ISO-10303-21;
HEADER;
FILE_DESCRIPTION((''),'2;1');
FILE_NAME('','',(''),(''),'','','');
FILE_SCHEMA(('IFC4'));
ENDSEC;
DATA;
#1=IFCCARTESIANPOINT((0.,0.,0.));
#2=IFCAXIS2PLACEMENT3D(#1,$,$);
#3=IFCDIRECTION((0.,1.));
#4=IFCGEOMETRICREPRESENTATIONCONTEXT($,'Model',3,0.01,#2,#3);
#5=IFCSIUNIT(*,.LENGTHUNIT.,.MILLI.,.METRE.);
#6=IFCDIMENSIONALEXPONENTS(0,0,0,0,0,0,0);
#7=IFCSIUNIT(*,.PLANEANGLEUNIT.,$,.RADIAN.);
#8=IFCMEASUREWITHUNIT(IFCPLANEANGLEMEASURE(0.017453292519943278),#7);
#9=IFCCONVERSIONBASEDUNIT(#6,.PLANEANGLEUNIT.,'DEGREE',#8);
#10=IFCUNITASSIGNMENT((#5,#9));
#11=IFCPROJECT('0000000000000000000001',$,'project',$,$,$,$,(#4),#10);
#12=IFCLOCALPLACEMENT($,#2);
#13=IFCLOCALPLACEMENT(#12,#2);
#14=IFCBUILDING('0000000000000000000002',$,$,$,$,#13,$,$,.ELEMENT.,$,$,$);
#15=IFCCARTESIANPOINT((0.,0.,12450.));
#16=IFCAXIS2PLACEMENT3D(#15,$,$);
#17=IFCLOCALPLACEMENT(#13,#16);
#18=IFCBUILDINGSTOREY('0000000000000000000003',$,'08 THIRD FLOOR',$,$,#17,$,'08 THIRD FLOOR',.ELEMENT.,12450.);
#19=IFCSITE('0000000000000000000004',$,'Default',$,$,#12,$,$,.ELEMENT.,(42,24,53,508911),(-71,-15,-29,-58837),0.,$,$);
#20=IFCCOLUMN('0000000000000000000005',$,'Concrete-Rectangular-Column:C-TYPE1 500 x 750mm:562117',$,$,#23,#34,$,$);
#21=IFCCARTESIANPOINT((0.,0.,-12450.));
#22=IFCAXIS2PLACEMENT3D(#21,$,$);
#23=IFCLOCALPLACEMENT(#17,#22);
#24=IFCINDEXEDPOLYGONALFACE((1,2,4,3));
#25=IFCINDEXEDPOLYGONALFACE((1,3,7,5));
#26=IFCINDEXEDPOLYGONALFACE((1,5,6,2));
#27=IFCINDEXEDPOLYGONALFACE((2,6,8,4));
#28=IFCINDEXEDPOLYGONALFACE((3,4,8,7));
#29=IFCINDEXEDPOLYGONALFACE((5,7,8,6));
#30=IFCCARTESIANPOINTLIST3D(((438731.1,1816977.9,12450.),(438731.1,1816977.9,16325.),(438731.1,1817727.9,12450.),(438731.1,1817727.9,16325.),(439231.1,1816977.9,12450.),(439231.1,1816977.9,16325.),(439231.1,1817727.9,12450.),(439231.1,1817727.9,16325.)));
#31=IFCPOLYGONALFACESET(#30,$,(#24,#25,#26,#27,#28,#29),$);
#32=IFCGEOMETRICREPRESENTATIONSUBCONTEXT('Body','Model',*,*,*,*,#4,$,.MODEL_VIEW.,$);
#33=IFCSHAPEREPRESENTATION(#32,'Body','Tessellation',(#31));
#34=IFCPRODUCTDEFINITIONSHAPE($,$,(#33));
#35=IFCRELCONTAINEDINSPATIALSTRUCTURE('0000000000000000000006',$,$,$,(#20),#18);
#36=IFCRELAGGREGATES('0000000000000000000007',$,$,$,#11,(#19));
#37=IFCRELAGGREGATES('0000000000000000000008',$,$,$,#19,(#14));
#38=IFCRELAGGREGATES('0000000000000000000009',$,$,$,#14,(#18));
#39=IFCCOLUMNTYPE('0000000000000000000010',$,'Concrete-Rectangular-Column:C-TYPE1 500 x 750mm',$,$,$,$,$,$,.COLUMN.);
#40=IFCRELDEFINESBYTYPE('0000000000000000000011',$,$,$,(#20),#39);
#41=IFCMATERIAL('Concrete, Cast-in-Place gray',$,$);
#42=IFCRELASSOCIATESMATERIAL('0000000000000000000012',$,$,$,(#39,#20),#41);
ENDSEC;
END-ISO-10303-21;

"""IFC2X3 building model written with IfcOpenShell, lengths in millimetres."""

from ifc_helpers import new_model, entity, si_unit, converted_unit, direction, frame, frame_2d, origin, place, context, subcontext, project, spatial, rectangle, extrude, source, transform, mapped, material, type_object, type_shapes, element, save


model = new_model("IFC2X3")

# Units and contexts
model_context = context("Model", 3, precision=0.01, world=origin(), true_north=direction((0.0, 1.0)))
body_context = subcontext(model_context, "Body", "Model", "MODEL_VIEW")
ifc_project = project(units=[si_unit("LENGTHUNIT", "METRE", prefix="MILLI"), converted_unit("PLANEANGLEUNIT", "DEGREE", entity("IfcPlaneAngleMeasure", 0.017453292519943278), si_unit("PLANEANGLEUNIT", "RADIAN"), dimensions=[0, 0, 0, 0, 0, 0, 0])], contexts=[model_context])

# Site, building, storey
site_placement = place(None, origin())
site = spatial("IfcSite", under=ifc_project, at=site_placement, Name="Default", CompositionType="ELEMENT", RefLatitude=(42, 24, 53, 508911), RefLongitude=(-71, -15, -29, -58837), RefElevation=0.0)
building_placement = place(site_placement, origin())
building = spatial("IfcBuilding", under=site, at=building_placement, CompositionType="ELEMENT")
storey_placement = place(building_placement, frame((0.0, 0.0, 12450.0)))
storey = spatial("IfcBuildingStorey", under=building, at=storey_placement, Name="08 THIRD FLOOR", LongName="08 THIRD FLOOR", CompositionType="ELEMENT", Elevation=12450.0)

# Column
ifc_material_1 = material(Name="Concrete, Cast-in-Place gray")
column_type = type_object("IfcColumnType", Name="Concrete-Rectangular-Column:C-TYPE1 500 x 750mm", PredefinedType="COLUMN", material=ifc_material_1)
shared_shape = source(origin(), body_context, "Body", "SweptSolid", [
    extrude(rectangle(XDim=3875.0, YDim=750.0, at=frame_2d((0.0, 0.0), x_axis=(1.0, 0.0))), frame((438731.1, 1817352.9, 14387.5), z_axis=(1.0, 0.0, 0.0), x_axis=(0.0, 0.0, 1.0)), (0.0, 0.0, 1.0), 500.0),
])
type_shapes(column_type, [shared_shape])
column_placement = place(storey_placement, frame((0.0, 0.0, -12450.0)))
element("IfcColumn", 1, at=column_placement, inside=storey, type_object=column_type, material=ifc_material_1, Name="Concrete-Rectangular-Column:C-TYPE1 500 x 750mm:562117", context=body_context, shape_type="MappedRepresentation", body=[
    mapped(shared_shape, transform((0.0, 0.0, 0.0), scale=1.0)),
])

save(model, "model.ifc")
